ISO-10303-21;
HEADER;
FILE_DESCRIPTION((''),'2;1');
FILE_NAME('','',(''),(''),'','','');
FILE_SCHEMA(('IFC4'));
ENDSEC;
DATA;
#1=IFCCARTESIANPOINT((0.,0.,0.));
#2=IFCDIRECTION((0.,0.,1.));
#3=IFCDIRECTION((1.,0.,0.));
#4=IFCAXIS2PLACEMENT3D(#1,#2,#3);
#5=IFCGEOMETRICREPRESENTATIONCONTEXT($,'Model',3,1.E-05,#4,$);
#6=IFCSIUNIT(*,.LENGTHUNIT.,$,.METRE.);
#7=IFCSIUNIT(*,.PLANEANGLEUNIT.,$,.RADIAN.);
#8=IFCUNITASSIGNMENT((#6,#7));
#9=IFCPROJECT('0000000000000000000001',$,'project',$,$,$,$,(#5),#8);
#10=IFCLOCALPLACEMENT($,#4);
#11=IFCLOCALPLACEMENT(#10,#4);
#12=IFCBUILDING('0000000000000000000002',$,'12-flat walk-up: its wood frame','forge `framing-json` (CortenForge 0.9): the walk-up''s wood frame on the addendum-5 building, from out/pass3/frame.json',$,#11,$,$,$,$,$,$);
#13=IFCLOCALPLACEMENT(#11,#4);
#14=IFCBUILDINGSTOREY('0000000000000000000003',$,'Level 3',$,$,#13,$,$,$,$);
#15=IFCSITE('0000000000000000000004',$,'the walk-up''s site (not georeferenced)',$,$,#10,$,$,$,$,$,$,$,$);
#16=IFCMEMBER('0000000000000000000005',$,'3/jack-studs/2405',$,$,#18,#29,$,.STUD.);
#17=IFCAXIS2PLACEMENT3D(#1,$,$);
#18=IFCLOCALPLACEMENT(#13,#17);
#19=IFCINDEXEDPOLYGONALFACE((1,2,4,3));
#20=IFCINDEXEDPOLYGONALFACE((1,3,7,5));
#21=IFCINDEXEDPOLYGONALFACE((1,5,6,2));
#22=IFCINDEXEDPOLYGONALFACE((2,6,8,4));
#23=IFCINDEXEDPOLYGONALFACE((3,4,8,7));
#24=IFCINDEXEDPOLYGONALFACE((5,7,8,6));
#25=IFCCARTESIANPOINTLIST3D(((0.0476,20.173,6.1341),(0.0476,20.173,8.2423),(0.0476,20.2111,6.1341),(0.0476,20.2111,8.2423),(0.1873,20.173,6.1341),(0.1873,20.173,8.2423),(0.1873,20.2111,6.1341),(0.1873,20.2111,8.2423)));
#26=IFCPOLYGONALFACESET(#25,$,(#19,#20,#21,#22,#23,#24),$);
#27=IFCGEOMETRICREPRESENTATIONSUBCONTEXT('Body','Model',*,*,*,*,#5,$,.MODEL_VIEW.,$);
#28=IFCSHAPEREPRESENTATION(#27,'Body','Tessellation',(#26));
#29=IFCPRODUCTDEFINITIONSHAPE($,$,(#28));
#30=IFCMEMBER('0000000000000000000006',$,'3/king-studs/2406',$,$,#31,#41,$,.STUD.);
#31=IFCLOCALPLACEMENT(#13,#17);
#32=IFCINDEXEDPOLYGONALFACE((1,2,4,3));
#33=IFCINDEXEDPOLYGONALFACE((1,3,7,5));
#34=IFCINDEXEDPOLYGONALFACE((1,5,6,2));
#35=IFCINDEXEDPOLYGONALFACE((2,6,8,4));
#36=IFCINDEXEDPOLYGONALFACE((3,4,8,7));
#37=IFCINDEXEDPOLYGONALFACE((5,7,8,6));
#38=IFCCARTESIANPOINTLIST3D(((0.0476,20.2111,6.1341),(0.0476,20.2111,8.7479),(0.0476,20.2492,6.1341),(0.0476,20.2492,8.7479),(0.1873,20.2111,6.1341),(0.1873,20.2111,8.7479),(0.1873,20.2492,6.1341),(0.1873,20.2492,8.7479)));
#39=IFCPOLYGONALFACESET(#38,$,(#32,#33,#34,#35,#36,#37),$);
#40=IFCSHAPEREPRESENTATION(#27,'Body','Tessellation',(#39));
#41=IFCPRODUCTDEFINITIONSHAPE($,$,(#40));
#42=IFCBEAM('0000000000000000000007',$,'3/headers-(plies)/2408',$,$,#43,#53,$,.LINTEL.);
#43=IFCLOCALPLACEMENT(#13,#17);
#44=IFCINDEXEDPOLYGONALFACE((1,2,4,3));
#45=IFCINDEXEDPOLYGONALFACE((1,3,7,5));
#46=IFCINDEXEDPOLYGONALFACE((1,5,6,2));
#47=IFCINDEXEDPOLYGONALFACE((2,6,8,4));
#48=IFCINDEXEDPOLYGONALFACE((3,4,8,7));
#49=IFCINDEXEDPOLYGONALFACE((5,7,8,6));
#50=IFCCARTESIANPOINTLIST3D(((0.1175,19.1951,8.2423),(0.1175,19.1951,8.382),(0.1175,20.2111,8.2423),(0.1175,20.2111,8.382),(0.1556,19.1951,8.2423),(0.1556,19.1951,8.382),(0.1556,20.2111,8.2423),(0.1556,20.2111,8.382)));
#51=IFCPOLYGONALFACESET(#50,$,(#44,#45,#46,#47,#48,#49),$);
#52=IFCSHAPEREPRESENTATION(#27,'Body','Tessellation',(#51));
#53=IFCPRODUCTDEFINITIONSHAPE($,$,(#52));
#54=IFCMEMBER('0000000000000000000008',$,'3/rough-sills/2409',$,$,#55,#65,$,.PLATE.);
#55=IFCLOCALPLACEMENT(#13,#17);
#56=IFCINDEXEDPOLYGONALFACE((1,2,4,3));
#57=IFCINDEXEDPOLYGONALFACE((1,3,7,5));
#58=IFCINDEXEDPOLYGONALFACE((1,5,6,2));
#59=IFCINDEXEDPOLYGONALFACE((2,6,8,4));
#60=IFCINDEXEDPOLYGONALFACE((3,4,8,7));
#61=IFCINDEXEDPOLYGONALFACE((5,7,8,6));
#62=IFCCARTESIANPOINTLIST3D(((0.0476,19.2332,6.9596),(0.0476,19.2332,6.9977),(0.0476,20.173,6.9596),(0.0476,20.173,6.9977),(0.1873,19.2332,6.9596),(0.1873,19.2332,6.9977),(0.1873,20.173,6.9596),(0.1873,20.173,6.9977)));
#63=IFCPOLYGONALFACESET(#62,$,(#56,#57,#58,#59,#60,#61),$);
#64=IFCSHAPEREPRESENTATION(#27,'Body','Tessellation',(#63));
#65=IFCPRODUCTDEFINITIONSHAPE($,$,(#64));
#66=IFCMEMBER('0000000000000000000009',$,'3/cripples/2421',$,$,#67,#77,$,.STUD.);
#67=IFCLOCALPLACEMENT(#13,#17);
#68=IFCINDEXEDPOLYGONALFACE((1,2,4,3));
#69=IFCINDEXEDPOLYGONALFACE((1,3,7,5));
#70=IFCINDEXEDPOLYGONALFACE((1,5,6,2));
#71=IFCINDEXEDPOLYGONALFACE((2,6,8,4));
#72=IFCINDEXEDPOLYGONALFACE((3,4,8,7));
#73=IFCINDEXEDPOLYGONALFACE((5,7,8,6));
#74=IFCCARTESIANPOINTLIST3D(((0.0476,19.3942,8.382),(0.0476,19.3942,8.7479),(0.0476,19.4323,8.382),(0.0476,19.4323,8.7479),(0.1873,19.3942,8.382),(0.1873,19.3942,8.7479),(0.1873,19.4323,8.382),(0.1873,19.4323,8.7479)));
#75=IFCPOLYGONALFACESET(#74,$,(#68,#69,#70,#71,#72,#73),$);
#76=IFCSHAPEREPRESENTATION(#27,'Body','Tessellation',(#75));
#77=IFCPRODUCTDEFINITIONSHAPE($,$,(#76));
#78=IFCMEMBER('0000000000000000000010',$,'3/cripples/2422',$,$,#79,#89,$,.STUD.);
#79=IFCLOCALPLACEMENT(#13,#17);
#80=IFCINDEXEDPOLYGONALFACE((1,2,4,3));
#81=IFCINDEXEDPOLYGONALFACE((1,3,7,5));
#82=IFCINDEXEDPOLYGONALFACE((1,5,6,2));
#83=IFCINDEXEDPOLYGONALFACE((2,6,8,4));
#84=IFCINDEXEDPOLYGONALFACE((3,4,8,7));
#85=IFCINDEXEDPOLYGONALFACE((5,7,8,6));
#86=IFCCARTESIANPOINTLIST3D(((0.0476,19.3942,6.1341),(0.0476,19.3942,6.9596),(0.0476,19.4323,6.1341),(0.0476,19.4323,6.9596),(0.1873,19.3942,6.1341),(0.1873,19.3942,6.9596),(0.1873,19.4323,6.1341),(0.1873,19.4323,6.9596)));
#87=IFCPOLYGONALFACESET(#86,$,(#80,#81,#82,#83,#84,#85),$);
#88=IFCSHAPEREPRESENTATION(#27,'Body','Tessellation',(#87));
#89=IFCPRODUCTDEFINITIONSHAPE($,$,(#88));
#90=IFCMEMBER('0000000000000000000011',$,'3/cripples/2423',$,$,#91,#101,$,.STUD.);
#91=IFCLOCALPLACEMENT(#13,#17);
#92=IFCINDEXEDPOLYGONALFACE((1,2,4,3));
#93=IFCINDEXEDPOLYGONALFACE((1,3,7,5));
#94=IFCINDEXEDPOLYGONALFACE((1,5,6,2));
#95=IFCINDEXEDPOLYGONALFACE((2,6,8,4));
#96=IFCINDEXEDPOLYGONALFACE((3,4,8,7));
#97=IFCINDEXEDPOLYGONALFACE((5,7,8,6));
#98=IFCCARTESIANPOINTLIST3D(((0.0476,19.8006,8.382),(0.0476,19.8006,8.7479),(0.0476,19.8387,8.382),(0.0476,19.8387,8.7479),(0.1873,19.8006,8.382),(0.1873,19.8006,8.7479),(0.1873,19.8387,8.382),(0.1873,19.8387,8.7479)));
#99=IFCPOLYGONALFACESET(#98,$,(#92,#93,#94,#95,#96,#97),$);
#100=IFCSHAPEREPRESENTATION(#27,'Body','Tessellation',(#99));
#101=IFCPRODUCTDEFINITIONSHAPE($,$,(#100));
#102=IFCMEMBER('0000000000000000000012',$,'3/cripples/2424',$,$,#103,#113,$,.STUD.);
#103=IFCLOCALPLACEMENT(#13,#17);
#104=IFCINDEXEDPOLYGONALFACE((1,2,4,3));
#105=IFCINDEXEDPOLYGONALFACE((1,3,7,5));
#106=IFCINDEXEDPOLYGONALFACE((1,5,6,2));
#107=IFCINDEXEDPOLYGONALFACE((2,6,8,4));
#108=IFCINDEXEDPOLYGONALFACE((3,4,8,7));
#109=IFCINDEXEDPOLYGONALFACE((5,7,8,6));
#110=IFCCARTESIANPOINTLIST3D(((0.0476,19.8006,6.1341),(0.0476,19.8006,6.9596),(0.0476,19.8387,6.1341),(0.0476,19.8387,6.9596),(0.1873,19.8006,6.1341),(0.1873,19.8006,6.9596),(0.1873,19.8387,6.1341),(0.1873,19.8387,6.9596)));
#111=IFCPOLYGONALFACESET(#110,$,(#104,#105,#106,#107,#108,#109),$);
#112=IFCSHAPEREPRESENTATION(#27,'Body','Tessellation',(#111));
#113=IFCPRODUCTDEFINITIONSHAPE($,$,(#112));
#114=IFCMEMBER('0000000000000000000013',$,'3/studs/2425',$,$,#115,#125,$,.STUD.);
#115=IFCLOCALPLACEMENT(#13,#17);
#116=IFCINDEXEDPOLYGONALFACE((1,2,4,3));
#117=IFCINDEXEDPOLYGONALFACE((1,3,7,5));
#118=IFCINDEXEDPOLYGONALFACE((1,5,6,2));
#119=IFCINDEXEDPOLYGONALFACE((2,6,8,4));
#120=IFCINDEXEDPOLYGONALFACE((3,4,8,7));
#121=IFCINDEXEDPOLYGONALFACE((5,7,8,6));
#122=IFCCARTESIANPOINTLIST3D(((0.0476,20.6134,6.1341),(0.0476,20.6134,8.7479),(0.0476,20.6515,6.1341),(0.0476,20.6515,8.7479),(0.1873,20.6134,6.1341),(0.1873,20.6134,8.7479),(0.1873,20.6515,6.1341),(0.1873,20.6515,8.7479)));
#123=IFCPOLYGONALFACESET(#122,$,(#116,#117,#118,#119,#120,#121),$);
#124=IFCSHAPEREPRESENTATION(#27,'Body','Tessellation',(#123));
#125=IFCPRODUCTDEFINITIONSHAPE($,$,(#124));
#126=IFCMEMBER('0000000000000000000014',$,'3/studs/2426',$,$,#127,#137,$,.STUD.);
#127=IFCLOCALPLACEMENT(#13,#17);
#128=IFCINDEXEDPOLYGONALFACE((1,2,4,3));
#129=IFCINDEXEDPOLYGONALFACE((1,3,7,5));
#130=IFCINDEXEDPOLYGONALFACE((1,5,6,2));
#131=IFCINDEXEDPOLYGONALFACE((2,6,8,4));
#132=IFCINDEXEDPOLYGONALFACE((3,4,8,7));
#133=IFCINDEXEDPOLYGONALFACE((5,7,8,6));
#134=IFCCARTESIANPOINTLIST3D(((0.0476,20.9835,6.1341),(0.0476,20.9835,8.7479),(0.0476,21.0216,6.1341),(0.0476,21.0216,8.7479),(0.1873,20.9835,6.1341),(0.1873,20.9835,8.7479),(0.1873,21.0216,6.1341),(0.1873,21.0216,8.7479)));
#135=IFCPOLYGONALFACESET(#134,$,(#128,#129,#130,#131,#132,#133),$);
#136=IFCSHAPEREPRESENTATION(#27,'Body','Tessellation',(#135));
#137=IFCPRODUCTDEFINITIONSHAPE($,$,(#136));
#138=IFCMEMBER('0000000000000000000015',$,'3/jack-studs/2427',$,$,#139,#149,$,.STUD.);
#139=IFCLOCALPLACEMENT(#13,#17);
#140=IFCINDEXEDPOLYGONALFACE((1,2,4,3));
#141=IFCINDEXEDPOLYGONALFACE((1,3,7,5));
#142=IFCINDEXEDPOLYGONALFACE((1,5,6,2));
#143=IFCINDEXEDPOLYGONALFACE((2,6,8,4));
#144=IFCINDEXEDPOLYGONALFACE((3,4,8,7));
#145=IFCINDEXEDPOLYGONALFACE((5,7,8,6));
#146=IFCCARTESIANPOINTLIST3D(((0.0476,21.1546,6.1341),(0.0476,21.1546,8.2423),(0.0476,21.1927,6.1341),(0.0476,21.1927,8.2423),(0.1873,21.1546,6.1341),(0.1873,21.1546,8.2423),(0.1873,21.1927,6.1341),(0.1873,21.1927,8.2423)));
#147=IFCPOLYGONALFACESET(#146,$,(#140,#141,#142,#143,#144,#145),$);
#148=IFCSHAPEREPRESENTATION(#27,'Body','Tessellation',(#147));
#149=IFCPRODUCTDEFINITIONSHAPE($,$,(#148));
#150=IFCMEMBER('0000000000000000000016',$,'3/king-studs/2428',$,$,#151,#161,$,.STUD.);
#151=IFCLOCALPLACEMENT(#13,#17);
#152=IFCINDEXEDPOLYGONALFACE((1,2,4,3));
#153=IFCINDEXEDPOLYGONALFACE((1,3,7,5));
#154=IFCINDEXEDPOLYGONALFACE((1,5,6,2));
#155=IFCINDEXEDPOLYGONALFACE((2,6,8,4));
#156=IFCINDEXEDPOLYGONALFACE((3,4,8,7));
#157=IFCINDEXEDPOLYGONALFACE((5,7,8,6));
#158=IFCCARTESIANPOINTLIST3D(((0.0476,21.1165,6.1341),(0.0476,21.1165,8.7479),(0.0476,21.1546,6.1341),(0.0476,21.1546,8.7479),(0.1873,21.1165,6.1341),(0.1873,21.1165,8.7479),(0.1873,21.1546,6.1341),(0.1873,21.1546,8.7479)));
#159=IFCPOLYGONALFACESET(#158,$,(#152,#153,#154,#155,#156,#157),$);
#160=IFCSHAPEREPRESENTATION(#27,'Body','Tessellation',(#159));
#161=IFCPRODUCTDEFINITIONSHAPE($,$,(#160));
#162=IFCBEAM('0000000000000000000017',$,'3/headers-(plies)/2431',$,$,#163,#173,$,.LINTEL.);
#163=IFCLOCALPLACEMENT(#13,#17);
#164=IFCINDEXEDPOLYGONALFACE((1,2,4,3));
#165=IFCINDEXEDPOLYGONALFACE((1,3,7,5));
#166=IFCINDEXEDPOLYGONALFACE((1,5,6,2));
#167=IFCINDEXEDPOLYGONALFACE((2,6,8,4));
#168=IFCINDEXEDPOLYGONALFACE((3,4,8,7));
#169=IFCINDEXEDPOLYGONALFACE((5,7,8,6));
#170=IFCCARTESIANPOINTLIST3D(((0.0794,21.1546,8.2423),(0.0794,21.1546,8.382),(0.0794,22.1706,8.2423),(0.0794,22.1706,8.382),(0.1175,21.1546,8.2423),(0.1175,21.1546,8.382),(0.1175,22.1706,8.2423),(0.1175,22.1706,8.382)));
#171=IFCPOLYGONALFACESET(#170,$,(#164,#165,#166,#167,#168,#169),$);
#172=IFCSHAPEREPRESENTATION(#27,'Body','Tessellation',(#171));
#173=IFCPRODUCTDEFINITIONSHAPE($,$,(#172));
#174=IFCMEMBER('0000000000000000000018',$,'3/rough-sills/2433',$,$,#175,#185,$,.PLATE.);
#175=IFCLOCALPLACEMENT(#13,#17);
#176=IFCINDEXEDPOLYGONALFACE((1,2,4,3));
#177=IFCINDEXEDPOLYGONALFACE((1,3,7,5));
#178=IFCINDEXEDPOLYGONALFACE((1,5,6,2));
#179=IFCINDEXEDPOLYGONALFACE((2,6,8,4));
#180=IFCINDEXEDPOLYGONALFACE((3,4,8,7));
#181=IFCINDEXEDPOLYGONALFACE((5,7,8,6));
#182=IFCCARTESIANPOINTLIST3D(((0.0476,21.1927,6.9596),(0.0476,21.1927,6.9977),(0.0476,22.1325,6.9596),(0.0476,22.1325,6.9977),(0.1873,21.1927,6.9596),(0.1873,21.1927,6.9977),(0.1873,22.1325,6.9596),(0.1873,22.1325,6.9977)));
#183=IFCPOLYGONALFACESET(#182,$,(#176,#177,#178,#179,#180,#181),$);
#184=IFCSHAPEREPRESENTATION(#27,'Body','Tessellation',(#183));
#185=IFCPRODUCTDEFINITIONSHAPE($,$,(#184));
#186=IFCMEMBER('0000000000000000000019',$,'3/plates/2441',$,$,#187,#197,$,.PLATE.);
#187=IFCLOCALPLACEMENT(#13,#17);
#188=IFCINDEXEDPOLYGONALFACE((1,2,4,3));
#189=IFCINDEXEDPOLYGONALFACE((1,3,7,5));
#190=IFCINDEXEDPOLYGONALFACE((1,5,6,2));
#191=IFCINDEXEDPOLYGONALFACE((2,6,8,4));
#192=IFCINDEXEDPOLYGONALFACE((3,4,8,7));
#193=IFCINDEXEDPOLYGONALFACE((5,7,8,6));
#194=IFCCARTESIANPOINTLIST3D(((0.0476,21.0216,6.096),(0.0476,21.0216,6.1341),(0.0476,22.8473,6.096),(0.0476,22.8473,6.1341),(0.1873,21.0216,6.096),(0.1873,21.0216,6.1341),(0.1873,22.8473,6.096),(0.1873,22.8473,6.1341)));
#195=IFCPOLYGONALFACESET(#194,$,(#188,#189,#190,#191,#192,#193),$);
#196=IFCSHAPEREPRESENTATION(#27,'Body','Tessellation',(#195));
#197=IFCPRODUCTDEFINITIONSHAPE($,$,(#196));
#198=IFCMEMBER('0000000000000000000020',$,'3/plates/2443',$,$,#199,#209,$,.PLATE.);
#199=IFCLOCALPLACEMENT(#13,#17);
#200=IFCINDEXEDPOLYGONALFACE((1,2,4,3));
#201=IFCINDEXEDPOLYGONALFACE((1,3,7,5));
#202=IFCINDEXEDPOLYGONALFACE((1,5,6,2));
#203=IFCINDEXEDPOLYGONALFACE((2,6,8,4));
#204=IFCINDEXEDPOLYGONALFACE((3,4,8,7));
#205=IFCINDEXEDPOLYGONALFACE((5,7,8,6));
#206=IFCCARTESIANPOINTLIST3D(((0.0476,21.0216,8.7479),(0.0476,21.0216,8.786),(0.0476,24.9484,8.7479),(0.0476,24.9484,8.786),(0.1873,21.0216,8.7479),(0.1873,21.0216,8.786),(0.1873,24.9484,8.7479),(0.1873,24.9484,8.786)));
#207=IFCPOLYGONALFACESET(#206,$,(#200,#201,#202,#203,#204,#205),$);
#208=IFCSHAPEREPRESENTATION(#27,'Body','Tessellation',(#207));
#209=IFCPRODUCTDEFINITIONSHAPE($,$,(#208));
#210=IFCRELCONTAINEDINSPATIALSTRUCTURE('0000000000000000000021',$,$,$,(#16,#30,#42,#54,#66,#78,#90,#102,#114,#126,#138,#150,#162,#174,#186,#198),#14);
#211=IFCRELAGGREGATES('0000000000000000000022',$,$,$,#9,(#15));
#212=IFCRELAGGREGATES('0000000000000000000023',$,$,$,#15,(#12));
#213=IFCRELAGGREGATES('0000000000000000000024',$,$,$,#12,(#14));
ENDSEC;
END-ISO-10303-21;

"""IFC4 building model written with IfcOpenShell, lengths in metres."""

from ifc_helpers import new_model, si_unit, frame, frame_2d, origin, origin_with_axes, place, context, subcontext, project, spatial, rectangle, extrude, element, save


model = new_model("IFC4")

# Units and contexts
model_context = context("Model", 3, precision=1e-05, world=origin_with_axes())
body_context = subcontext(model_context, "Body", "Model", "MODEL_VIEW")
ifc_project = project(units=[si_unit("LENGTHUNIT", "METRE"), si_unit("PLANEANGLEUNIT", "RADIAN")], contexts=[model_context])

# Site, building, storey
site_placement = place(None, origin_with_axes())
site = spatial("IfcSite", under=ifc_project, at=site_placement, Name="the walk-up's site (not georeferenced)")
building_placement = place(site_placement, origin_with_axes())
building = spatial("IfcBuilding", under=site, at=building_placement, Name="12-flat walk-up: its wood frame", Description="forge `framing-json` (CortenForge 0.9): the walk-up's wood frame on the addendum-5 building, from out/pass3/frame.json")
storey_placement = place(building_placement, origin_with_axes())
storey = spatial("IfcBuildingStorey", under=building, at=storey_placement, Name="Level 3")

# Members
member_1_placement = place(storey_placement, frame((0.0476, 20.173, 6.1341), z_axis=(0.0, 0.0, 1.0), x_axis=(1.0, 0.0, 0.0)))
element("IfcMember", 1, at=member_1_placement, inside=storey, Name="3/jack-studs/2405", PredefinedType="STUD", context=body_context, shape_type="SweptSolid", body=[
    extrude(rectangle(XDim=0.1397, YDim=0.0381, at=frame_2d((0.0698, 0.0191))), origin(), (0.0, 0.0, 1.0), 2.1082),
])
member_2_placement = place(storey_placement, frame((0.0476, 20.2111, 6.1341), z_axis=(0.0, 0.0, 1.0), x_axis=(1.0, 0.0, 0.0)))
element("IfcMember", 2, at=member_2_placement, inside=storey, Name="3/king-studs/2406", PredefinedType="STUD", context=body_context, shape_type="SweptSolid", body=[
    extrude(rectangle(XDim=0.1397, YDim=0.0381, at=frame_2d((0.0698, 0.0191))), origin(), (0.0, 0.0, 1.0), 2.6138),
])

# Beam
beam_1_placement = place(storey_placement, frame((0.1175, 19.1951, 8.2423), z_axis=(0.0, 0.0, 1.0), x_axis=(1.0, 0.0, 0.0)))
element("IfcBeam", 3, at=beam_1_placement, inside=storey, Name="3/headers-(plies)/2408", PredefinedType="LINTEL", context=body_context, shape_type="SweptSolid", body=[
    extrude(rectangle(XDim=0.0381, YDim=1.016, at=frame_2d((0.019, 0.508))), origin(), (0.0, 0.0, 1.0), 0.1397),
])

# Members
member_3_placement = place(storey_placement, frame((0.0476, 19.2332, 6.9596), z_axis=(0.0, 0.0, 1.0), x_axis=(1.0, 0.0, 0.0)))
element("IfcMember", 4, at=member_3_placement, inside=storey, Name="3/rough-sills/2409", PredefinedType="PLATE", context=body_context, shape_type="SweptSolid", body=[
    extrude(rectangle(XDim=0.1397, YDim=0.9398, at=frame_2d((0.0698, 0.4699))), origin(), (0.0, 0.0, 1.0), 0.0381),
])
member_4_placement = place(storey_placement, frame((0.0476, 19.3942, 8.382), z_axis=(0.0, 0.0, 1.0), x_axis=(1.0, 0.0, 0.0)))
element("IfcMember", 5, at=member_4_placement, inside=storey, Name="3/cripples/2421", PredefinedType="STUD", context=body_context, shape_type="SweptSolid", body=[
    extrude(rectangle(XDim=0.1397, YDim=0.0381, at=frame_2d((0.0698, 0.0191))), origin(), (0.0, 0.0, 1.0), 0.3659),
])
member_5_placement = place(storey_placement, frame((0.0476, 19.3942, 6.1341), z_axis=(0.0, 0.0, 1.0), x_axis=(1.0, 0.0, 0.0)))
element("IfcMember", 6, at=member_5_placement, inside=storey, Name="3/cripples/2422", PredefinedType="STUD", context=body_context, shape_type="SweptSolid", body=[
    extrude(rectangle(XDim=0.1397, YDim=0.0381, at=frame_2d((0.0698, 0.0191))), origin(), (0.0, 0.0, 1.0), 0.8255),
])
member_6_placement = place(storey_placement, frame((0.0476, 19.8006, 8.382), z_axis=(0.0, 0.0, 1.0), x_axis=(1.0, 0.0, 0.0)))
element("IfcMember", 7, at=member_6_placement, inside=storey, Name="3/cripples/2423", PredefinedType="STUD", context=body_context, shape_type="SweptSolid", body=[
    extrude(rectangle(XDim=0.1397, YDim=0.0381, at=frame_2d((0.0698, 0.0191))), origin(), (0.0, 0.0, 1.0), 0.3659),
])
member_7_placement = place(storey_placement, frame((0.0476, 19.8006, 6.1341), z_axis=(0.0, 0.0, 1.0), x_axis=(1.0, 0.0, 0.0)))
element("IfcMember", 8, at=member_7_placement, inside=storey, Name="3/cripples/2424", PredefinedType="STUD", context=body_context, shape_type="SweptSolid", body=[
    extrude(rectangle(XDim=0.1397, YDim=0.0381, at=frame_2d((0.0698, 0.0191))), origin(), (0.0, 0.0, 1.0), 0.8255),
])
for number, where, z_axis, x_axis, name in (
    (9, (0.0476, 20.6134, 6.1341), (0.0, 0.0, 1.0), (1.0, 0.0, 0.0), "3/studs/2425"),
    (10, (0.0476, 20.9835, 6.1341), (0.0, 0.0, 1.0), (1.0, 0.0, 0.0), "3/studs/2426"),
):
    element("IfcMember", number, at=place(storey_placement, frame(where, z_axis=z_axis, x_axis=x_axis)), inside=storey, Name=name, PredefinedType="STUD", context=body_context, shape_type="SweptSolid", body=[
        extrude(rectangle(XDim=0.1397, YDim=0.0381, at=frame_2d((0.0698, 0.0191))), origin(), (0.0, 0.0, 1.0), 2.6138),
    ])
member_8_placement = place(storey_placement, frame((0.0476, 21.1546, 6.1341), z_axis=(0.0, 0.0, 1.0), x_axis=(1.0, 0.0, 0.0)))
element("IfcMember", 11, at=member_8_placement, inside=storey, Name="3/jack-studs/2427", PredefinedType="STUD", context=body_context, shape_type="SweptSolid", body=[
    extrude(rectangle(XDim=0.1397, YDim=0.0381, at=frame_2d((0.0698, 0.0191))), origin(), (0.0, 0.0, 1.0), 2.1082),
])
member_9_placement = place(storey_placement, frame((0.0476, 21.1165, 6.1341), z_axis=(0.0, 0.0, 1.0), x_axis=(1.0, 0.0, 0.0)))
element("IfcMember", 12, at=member_9_placement, inside=storey, Name="3/king-studs/2428", PredefinedType="STUD", context=body_context, shape_type="SweptSolid", body=[
    extrude(rectangle(XDim=0.1397, YDim=0.0381, at=frame_2d((0.0698, 0.0191))), origin(), (0.0, 0.0, 1.0), 2.6138),
])

# Beam
beam_2_placement = place(storey_placement, frame((0.0794, 21.1546, 8.2423), z_axis=(0.0, 0.0, 1.0), x_axis=(1.0, 0.0, 0.0)))
element("IfcBeam", 13, at=beam_2_placement, inside=storey, Name="3/headers-(plies)/2431", PredefinedType="LINTEL", context=body_context, shape_type="SweptSolid", body=[
    extrude(rectangle(XDim=0.0381, YDim=1.016, at=frame_2d((0.019, 0.508))), origin(), (0.0, 0.0, 1.0), 0.1397),
])

# Members
member_10_placement = place(storey_placement, frame((0.0476, 21.1927, 6.9596), z_axis=(0.0, 0.0, 1.0), x_axis=(1.0, 0.0, 0.0)))
element("IfcMember", 14, at=member_10_placement, inside=storey, Name="3/rough-sills/2433", PredefinedType="PLATE", context=body_context, shape_type="SweptSolid", body=[
    extrude(rectangle(XDim=0.1397, YDim=0.9398, at=frame_2d((0.0698, 0.4699))), origin(), (0.0, 0.0, 1.0), 0.0381),
])
member_11_placement = place(storey_placement, frame((0.0476, 21.0216, 6.096), z_axis=(0.0, 0.0, 1.0), x_axis=(1.0, 0.0, 0.0)))
element("IfcMember", 15, at=member_11_placement, inside=storey, Name="3/plates/2441", PredefinedType="PLATE", context=body_context, shape_type="SweptSolid", body=[
    extrude(rectangle(XDim=0.1397, YDim=1.8257, at=frame_2d((0.0698, 0.9128))), origin(), (0.0, 0.0, 1.0), 0.0381),
])
member_12_placement = place(storey_placement, frame((0.0476, 21.0216, 8.7479), z_axis=(0.0, 0.0, 1.0), x_axis=(1.0, 0.0, 0.0)))
element("IfcMember", 16, at=member_12_placement, inside=storey, Name="3/plates/2443", PredefinedType="PLATE", context=body_context, shape_type="SweptSolid", body=[
    extrude(rectangle(XDim=0.1397, YDim=3.9268, at=frame_2d((0.0698, 1.9634))), origin(), (0.0, 0.0, 1.0), 0.0381),
])

save(model, "model.ifc")
